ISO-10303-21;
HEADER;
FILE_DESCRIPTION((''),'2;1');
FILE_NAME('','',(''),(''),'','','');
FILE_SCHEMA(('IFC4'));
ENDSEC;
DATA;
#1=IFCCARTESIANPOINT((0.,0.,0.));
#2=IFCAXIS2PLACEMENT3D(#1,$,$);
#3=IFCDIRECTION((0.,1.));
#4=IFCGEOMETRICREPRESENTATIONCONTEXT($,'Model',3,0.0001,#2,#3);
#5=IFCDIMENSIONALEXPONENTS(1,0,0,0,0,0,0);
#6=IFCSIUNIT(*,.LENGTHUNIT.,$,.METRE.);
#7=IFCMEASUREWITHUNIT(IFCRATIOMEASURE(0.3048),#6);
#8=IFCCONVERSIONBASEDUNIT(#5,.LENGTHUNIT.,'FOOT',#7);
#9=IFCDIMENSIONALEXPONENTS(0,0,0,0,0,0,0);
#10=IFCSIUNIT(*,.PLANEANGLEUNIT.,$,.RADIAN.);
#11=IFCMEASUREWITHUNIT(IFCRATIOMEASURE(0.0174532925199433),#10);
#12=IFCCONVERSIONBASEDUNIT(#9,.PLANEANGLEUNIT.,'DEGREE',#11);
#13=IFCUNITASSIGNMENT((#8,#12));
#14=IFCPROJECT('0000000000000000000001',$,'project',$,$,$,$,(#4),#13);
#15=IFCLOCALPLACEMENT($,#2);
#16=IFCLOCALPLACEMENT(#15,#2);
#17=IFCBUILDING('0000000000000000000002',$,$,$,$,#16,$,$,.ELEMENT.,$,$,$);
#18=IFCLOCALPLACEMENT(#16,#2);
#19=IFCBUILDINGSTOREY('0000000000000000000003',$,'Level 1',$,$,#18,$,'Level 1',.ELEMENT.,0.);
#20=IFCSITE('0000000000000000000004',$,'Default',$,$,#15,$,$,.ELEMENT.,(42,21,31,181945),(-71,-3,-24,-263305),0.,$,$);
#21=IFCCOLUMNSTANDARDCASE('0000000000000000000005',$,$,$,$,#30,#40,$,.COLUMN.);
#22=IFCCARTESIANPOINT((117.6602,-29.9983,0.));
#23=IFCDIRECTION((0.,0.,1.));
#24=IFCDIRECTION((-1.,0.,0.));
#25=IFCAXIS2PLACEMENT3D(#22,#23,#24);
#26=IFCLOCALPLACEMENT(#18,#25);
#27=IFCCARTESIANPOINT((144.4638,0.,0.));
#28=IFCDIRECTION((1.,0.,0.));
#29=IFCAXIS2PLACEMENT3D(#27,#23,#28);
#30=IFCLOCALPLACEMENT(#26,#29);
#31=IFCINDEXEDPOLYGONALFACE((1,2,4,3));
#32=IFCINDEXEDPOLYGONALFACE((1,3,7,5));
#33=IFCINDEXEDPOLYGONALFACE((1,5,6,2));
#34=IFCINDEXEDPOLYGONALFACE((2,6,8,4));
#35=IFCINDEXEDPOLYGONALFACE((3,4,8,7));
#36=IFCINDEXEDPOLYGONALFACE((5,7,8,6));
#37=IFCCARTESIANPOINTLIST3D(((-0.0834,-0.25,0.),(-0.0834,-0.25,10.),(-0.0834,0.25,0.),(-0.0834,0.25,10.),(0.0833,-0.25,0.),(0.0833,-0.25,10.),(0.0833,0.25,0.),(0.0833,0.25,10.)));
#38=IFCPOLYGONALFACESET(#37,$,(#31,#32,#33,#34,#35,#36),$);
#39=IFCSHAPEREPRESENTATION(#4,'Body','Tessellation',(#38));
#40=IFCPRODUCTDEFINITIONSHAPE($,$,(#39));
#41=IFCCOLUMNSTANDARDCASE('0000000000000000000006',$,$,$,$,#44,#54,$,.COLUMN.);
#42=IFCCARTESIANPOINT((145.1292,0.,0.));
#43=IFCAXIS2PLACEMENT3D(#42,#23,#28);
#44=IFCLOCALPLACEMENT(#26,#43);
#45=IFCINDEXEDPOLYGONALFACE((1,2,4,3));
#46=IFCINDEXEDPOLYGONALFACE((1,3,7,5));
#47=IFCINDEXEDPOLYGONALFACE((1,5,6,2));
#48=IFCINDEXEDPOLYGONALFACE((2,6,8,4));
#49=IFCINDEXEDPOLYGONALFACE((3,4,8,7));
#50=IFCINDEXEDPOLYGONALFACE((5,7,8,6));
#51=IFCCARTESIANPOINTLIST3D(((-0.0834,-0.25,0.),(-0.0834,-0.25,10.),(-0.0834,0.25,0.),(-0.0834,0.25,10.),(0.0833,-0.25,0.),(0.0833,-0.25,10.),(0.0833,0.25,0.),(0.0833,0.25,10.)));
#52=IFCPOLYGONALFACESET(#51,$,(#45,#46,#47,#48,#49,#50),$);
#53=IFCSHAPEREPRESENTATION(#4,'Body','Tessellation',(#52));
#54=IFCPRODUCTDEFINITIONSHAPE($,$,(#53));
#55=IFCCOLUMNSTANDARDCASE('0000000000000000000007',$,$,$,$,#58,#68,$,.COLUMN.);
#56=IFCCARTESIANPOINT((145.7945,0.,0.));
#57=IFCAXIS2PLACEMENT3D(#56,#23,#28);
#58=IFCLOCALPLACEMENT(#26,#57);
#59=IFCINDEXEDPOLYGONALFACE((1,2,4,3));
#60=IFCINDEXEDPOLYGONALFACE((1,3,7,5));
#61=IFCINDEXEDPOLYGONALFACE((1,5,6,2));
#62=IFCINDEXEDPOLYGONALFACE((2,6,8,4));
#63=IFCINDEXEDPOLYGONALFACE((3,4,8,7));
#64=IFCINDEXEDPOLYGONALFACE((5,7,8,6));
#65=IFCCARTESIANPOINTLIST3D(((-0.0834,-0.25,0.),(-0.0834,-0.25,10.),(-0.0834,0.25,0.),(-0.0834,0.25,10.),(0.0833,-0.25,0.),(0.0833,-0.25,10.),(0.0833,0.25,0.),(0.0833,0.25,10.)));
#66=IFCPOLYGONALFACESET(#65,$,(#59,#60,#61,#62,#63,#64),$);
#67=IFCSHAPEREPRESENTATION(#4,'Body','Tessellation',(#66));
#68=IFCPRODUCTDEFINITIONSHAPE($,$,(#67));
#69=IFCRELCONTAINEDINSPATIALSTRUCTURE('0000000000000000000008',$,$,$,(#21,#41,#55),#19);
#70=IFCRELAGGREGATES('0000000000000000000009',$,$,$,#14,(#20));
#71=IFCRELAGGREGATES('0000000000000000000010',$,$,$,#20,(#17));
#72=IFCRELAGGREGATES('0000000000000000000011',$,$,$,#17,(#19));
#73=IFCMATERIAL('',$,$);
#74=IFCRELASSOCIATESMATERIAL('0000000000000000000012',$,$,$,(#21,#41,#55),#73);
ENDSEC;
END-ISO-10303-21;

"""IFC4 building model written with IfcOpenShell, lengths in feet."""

from ifc_helpers import new_model, entity, si_unit, converted_unit, direction, frame, origin, place, context, project, spatial, rectangle, extrude, material, element, save


model = new_model("IFC4")

# Units and contexts
model_context = context("Model", 3, precision=0.0001, world=origin(), true_north=direction((0.0, 1.0)))
ifc_project = project(units=[converted_unit("LENGTHUNIT", "FOOT", entity("IfcRatioMeasure", 0.3048), si_unit("LENGTHUNIT", "METRE"), dimensions=[1, 0, 0, 0, 0, 0, 0]), converted_unit("PLANEANGLEUNIT", "DEGREE", entity("IfcRatioMeasure", 0.0174532925199433), si_unit("PLANEANGLEUNIT", "RADIAN"), dimensions=[0, 0, 0, 0, 0, 0, 0])], contexts=[model_context])

# Site, building, storey
site_placement = place(None, origin())
site = spatial("IfcSite", under=ifc_project, at=site_placement, Name="Default", CompositionType="ELEMENT", RefLatitude=(42, 21, 31, 181945), RefLongitude=(-71, -3, -24, -263305), RefElevation=0.0)
building_placement = place(site_placement, origin())
building = spatial("IfcBuilding", under=site, at=building_placement, CompositionType="ELEMENT")
storey_placement = place(building_placement, origin())
storey = spatial("IfcBuildingStorey", under=building, at=storey_placement, Name="Level 1", LongName="Level 1", CompositionType="ELEMENT", Elevation=0.0)

# Columns
ifc_material = material(Name="")
placement = place(storey_placement, frame((117.6602, -29.9983, 0.0), z_axis=(0.0, 0.0, 1.0), x_axis=(-1.0, 0.0, 0.0)))
for number, where, z_axis, x_axis in (
    (1, (144.4638, 0.0, 0.0), (0.0, 0.0, 1.0), (1.0, 0.0, 0.0)),
    (2, (145.1292, 0.0, 0.0), (0.0, 0.0, 1.0), (1.0, 0.0, 0.0)),
    (3, (145.7945, 0.0, 0.0), (0.0, 0.0, 1.0), (1.0, 0.0, 0.0)),
):
    element("IfcColumnStandardCase", number, at=place(placement, frame(where, z_axis=z_axis, x_axis=x_axis)), inside=storey, material=ifc_material, PredefinedType="COLUMN", context=model_context, shape_type="SweptSolid", body=[
        extrude(rectangle(XDim=0.1667, YDim=0.5), origin(), (0.0, 0.0, 1.0), 10.0),
    ])

save(model, "model.ifc")
